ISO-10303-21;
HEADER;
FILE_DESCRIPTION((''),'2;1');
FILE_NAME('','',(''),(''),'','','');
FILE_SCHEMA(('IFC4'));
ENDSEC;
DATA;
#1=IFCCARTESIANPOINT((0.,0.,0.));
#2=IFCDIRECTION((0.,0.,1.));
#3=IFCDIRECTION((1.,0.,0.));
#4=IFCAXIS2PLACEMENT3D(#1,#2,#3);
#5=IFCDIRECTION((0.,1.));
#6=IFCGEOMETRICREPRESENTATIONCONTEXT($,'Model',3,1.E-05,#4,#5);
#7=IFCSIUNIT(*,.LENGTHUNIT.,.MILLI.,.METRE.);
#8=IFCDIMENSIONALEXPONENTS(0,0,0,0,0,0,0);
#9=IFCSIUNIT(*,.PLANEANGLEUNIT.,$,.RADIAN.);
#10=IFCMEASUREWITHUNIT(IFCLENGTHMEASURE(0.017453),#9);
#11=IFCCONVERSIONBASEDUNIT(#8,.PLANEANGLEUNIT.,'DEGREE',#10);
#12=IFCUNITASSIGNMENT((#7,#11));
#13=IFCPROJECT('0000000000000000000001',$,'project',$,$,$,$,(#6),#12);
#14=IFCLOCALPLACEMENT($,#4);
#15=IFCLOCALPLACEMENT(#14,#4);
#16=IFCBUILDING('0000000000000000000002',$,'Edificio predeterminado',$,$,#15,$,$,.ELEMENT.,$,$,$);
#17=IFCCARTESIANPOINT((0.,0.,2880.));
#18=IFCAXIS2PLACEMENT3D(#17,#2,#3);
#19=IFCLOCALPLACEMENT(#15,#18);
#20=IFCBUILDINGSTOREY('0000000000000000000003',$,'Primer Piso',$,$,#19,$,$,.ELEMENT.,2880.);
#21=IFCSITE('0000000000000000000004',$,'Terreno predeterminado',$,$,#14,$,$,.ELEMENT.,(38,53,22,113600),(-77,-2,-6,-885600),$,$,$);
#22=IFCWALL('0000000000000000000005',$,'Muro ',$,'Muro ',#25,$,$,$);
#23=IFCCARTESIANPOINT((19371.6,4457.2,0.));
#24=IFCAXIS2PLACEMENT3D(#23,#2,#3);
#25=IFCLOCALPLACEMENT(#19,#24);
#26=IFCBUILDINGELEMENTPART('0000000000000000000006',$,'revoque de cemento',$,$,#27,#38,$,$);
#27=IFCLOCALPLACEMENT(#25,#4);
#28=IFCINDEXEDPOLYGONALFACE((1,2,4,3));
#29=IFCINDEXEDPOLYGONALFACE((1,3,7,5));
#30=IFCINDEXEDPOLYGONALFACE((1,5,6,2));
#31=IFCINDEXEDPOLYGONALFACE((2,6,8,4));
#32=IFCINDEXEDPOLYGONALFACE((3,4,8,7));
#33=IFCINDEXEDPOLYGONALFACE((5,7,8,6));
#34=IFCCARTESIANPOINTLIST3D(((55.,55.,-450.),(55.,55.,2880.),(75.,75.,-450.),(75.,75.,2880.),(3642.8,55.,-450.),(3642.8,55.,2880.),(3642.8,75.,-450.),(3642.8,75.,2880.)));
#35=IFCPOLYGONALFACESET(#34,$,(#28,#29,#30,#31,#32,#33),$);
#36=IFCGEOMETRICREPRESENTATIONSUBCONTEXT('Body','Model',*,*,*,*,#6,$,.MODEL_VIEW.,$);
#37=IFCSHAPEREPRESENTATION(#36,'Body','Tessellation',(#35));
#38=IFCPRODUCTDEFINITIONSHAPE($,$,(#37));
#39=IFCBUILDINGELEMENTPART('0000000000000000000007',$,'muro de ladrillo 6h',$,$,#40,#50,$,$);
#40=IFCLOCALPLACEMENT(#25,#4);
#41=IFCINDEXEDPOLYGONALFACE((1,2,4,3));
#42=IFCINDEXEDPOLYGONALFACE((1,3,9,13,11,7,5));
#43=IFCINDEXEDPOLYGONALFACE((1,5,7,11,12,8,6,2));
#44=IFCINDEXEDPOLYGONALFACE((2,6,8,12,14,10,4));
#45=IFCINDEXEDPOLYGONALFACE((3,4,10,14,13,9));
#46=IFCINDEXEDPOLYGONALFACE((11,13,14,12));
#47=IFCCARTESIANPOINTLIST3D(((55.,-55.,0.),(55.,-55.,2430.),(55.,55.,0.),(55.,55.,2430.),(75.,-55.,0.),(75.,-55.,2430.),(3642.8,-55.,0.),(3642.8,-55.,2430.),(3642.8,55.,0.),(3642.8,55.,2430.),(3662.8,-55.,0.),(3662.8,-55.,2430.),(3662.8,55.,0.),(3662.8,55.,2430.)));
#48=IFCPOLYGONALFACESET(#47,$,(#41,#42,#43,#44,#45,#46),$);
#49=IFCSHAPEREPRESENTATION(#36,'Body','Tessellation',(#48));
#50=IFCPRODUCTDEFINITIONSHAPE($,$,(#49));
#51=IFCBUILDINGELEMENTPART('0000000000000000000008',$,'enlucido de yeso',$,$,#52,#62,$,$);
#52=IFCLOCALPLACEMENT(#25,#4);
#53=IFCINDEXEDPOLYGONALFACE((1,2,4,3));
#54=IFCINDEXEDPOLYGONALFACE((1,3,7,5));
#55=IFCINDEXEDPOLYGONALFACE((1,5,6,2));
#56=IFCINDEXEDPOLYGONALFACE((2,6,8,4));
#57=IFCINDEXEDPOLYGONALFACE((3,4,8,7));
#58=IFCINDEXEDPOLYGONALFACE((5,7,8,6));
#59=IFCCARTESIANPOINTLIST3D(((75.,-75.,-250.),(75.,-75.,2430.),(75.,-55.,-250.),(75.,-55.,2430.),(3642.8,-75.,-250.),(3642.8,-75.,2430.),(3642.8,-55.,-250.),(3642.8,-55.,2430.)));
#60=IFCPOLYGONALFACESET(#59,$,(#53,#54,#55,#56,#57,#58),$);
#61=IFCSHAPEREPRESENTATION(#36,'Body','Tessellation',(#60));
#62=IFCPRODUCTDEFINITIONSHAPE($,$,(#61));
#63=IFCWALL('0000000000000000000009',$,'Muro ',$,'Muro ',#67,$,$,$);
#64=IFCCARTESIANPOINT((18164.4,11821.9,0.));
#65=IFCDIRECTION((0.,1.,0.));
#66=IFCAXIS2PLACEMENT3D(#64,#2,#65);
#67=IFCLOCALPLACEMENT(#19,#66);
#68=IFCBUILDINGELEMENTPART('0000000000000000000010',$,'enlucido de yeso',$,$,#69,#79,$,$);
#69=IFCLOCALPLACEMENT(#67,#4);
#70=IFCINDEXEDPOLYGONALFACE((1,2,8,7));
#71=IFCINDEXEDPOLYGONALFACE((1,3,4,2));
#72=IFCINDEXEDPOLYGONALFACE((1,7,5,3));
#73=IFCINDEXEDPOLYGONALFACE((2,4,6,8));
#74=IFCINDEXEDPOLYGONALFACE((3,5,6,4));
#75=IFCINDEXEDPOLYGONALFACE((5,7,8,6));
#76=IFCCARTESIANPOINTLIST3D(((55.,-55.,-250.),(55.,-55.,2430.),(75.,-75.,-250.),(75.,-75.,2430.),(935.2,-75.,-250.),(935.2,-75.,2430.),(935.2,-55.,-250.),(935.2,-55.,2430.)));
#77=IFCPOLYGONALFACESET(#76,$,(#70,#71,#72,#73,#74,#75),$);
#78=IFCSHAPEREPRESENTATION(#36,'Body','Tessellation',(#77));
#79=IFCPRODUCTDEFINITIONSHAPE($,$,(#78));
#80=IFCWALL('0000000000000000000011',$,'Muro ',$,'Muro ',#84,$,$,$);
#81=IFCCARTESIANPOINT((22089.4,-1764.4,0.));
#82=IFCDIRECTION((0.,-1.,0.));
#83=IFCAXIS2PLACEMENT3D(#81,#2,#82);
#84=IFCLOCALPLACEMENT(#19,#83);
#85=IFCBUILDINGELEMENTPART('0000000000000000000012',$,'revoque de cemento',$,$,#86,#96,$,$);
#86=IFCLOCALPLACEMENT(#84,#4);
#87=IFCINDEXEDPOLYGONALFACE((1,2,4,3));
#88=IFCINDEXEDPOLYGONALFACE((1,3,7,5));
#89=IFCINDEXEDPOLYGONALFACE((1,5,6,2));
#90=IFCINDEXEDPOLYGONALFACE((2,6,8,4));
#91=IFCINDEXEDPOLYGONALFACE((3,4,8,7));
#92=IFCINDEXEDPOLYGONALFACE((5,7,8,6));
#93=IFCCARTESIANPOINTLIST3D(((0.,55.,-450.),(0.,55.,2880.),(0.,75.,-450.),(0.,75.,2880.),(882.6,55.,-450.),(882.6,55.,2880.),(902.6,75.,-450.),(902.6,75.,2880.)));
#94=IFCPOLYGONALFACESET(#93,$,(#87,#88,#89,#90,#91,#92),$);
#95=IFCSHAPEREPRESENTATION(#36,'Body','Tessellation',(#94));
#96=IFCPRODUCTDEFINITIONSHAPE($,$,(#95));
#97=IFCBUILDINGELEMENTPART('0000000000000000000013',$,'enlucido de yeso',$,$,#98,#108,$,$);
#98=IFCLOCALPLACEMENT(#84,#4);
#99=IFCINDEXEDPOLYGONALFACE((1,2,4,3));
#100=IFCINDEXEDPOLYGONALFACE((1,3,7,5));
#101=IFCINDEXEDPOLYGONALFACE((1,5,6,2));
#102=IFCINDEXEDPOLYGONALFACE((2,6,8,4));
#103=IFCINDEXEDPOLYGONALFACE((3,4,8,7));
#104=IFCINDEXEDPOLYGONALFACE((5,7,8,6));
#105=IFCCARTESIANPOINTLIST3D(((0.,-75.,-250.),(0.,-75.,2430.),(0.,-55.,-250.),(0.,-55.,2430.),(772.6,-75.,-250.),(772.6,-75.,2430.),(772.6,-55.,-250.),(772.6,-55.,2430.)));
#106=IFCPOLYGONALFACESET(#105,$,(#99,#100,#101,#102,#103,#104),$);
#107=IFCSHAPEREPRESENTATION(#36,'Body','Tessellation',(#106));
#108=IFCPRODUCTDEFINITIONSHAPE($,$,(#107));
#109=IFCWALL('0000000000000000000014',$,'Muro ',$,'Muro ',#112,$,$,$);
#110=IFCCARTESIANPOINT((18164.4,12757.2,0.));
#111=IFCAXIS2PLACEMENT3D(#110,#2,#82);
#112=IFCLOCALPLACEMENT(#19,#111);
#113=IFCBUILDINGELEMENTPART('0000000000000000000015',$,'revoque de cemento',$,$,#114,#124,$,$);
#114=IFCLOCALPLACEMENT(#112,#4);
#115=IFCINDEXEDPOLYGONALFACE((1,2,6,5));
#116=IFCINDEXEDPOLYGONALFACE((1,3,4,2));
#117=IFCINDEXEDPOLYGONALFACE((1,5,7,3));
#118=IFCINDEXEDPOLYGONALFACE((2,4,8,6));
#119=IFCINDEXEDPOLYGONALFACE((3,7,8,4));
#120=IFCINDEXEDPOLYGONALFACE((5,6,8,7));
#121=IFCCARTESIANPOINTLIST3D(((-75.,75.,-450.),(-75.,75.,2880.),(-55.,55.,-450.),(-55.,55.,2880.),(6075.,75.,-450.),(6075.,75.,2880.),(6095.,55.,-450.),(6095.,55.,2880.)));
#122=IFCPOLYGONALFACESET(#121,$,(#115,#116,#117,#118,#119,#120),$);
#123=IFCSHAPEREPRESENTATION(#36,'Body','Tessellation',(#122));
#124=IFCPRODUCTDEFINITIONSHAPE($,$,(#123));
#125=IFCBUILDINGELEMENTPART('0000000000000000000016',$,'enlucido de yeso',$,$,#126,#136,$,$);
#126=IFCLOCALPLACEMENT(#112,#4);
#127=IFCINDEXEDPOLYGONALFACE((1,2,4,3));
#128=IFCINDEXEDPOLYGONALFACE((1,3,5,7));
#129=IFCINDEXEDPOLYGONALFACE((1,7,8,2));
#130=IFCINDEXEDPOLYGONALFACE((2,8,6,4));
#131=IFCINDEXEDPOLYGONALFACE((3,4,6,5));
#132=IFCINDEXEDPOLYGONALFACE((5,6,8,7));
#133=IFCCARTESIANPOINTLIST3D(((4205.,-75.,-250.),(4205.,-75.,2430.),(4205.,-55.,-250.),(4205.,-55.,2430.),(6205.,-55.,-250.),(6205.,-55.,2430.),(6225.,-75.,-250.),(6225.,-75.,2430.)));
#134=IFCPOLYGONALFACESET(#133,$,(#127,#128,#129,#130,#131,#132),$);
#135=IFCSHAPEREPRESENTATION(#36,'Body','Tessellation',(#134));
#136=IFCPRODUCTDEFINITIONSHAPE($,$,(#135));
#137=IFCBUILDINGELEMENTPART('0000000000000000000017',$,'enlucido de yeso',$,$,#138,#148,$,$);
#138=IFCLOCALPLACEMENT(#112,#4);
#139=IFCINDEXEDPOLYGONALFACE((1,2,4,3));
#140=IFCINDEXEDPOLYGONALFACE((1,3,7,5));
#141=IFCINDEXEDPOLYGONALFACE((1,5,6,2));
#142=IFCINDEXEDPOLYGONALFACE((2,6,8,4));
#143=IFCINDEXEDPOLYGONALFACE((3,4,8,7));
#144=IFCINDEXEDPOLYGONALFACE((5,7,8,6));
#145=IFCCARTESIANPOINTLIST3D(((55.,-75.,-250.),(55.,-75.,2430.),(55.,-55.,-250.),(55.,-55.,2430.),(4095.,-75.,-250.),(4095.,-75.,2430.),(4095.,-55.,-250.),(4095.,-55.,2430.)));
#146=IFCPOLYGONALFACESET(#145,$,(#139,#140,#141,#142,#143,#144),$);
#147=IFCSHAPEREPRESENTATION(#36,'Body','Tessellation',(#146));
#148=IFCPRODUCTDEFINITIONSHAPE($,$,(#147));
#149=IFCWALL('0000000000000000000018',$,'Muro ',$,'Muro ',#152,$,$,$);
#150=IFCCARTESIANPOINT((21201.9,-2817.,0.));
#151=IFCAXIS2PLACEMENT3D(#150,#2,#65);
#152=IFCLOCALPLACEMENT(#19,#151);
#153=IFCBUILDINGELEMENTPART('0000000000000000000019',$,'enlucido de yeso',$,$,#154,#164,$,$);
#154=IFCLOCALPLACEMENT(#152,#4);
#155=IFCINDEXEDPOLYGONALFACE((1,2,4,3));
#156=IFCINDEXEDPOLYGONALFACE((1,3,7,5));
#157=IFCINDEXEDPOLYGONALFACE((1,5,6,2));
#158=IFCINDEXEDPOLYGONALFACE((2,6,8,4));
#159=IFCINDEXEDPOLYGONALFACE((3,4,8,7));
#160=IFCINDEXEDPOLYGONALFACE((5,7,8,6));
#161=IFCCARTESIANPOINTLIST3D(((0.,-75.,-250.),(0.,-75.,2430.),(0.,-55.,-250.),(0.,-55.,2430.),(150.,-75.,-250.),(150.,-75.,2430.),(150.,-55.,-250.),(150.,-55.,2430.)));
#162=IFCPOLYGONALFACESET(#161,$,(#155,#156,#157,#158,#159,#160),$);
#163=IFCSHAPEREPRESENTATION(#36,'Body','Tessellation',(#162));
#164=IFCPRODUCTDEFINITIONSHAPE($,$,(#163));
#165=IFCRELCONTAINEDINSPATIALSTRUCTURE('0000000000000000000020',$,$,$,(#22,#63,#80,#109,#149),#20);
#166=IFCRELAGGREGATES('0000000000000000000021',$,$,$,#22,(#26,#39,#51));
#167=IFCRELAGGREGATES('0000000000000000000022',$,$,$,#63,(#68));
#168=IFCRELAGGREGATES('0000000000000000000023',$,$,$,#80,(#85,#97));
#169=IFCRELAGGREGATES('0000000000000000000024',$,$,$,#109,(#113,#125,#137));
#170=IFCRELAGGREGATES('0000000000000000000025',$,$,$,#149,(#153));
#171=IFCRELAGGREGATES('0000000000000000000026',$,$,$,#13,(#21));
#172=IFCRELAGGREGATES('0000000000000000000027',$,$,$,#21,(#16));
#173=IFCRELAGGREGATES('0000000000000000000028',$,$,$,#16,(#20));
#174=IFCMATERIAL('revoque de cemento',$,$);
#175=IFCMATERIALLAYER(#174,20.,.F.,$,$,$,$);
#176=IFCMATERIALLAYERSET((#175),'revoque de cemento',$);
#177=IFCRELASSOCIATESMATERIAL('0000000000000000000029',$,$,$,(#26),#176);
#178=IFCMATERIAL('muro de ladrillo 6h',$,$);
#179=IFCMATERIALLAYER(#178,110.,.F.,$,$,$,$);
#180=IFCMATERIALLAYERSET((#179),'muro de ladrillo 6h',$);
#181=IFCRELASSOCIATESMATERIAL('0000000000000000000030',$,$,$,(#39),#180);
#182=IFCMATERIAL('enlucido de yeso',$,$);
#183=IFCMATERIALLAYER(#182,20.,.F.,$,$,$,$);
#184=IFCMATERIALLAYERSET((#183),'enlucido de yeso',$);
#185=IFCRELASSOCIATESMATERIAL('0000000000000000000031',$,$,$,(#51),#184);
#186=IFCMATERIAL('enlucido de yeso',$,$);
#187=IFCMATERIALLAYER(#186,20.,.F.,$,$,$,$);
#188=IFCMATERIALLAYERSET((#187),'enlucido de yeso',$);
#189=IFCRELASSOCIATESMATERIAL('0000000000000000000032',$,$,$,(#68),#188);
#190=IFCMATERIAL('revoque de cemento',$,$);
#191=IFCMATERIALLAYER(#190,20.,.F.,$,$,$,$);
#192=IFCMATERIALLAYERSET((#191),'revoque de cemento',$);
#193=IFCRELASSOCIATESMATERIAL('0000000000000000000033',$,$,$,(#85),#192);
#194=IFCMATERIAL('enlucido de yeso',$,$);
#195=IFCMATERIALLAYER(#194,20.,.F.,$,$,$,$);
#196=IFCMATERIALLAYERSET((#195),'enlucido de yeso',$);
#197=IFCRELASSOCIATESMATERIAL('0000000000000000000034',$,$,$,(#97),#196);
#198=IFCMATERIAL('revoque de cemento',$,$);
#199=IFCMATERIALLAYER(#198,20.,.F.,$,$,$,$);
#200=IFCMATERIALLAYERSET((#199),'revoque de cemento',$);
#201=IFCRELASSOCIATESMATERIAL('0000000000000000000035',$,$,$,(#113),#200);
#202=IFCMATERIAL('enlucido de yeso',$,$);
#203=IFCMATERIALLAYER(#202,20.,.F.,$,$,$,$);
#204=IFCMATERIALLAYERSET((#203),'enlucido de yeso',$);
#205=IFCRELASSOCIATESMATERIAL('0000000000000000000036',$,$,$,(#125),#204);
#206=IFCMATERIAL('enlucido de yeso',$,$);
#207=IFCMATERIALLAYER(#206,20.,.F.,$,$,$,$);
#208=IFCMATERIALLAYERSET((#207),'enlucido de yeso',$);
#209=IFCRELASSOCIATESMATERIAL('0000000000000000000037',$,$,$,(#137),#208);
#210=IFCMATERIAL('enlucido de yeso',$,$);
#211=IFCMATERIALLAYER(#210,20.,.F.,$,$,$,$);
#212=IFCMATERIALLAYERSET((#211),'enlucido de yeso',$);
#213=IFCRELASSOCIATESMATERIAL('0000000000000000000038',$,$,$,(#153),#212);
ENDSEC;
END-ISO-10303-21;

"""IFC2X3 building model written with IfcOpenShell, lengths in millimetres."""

from ifc_helpers import new_model, entity, si_unit, converted_unit, direction, frame, origin_with_axes, place, context, subcontext, project, spatial, polyline, outline, extrude, clip, bounded_halfspace, material, layer, layer_set, layer_usage, element, aggregate, save


model = new_model("IFC2X3")

# Units and contexts
model_context = context("Model", 3, precision=1e-05, world=origin_with_axes(), true_north=direction((0.0, 1.0)))
body_context = subcontext(model_context, "Body", "Model", "MODEL_VIEW")
ifc_project = project(units=[si_unit("LENGTHUNIT", "METRE", prefix="MILLI"), converted_unit("PLANEANGLEUNIT", "DEGREE", entity("IfcLengthMeasure", 0.017453), si_unit("PLANEANGLEUNIT", "RADIAN"), dimensions=[0, 0, 0, 0, 0, 0, 0])], contexts=[model_context])

# Site, building, storey
site_placement = place(None, origin_with_axes())
site = spatial("IfcSite", under=ifc_project, at=site_placement, Name="Terreno predeterminado", CompositionType="ELEMENT", RefLatitude=(38, 53, 22, 113600), RefLongitude=(-77, -2, -6, -885600))
building_placement = place(site_placement, origin_with_axes())
building = spatial("IfcBuilding", under=site, at=building_placement, Name="Edificio predeterminado", CompositionType="ELEMENT")
storey_placement = place(building_placement, frame((0.0, 0.0, 2880.0), z_axis=(0.0, 0.0, 1.0), x_axis=(1.0, 0.0, 0.0)))
storey = spatial("IfcBuildingStorey", under=building, at=storey_placement, Name="Primer Piso", CompositionType="ELEMENT", Elevation=2880.0)

# Walls, building element parts
wall_1_placement = place(storey_placement, frame((19371.6, 4457.2, 0.0), z_axis=(0.0, 0.0, 1.0), x_axis=(1.0, 0.0, 0.0)))
wall_1 = element("IfcWall", 1, at=wall_1_placement, inside=storey, Name="Muro ", ObjectType="Muro ")
ifc_material_1 = material(Name="revoque de cemento")
ifc_layer_1 = layer(ifc_material_1, 20.0, ventilated=False)
ifc_layer_set_1 = layer_set([ifc_layer_1], Name="revoque de cemento")
ifc_layer_usage_1 = layer_usage(ifc_layer_set_1, "AXIS2", "NEGATIVE", -75.0)
building_element_part_1_placement = place(wall_1_placement, origin_with_axes())
building_element_part_1 = element("IfcBuildingElementPart", 2, at=building_element_part_1_placement, material=ifc_layer_usage_1, Name="revoque de cemento", context=body_context, shape_type="SweptSolid", body=[
    extrude(outline(polyline([(3642.8, 75.0), (3642.8, 55.0), (55.0, 55.0), (75.0, 75.0), (3642.8, 75.0)])), frame((0.0, 0.0, -450.0), z_axis=(0.0, 0.0, 1.0), x_axis=(1.0, 0.0, 0.0)), (0.0, 0.0, 1.0), 3330.0),
])
ifc_material_2 = material(Name="muro de ladrillo 6h")
ifc_layer_2 = layer(ifc_material_2, 110.0, ventilated=False)
ifc_layer_set_2 = layer_set([ifc_layer_2], Name="muro de ladrillo 6h")
ifc_layer_usage_2 = layer_usage(ifc_layer_set_2, "AXIS2", "NEGATIVE", -55.0)
building_element_part_2_placement = place(wall_1_placement, origin_with_axes())
building_element_part_2 = element("IfcBuildingElementPart", 3, at=building_element_part_2_placement, material=ifc_layer_usage_2, Name="muro de ladrillo 6h", context=body_context, shape_type="SweptSolid", body=[
    extrude(outline(polyline([(3662.8, 55.0), (3662.8, -55.0), (3642.8, -55.0), (75.0, -55.0), (55.0, -55.0), (55.0, 55.0), (3642.8, 55.0), (3662.8, 55.0)])), origin_with_axes(), (0.0, 0.0, 1.0), 2430.0),
])
ifc_material_3 = material(Name="enlucido de yeso")
ifc_layer_3 = layer(ifc_material_3, 20.0, ventilated=False)
ifc_layer_set_3 = layer_set([ifc_layer_3], Name="enlucido de yeso")
ifc_layer_usage_3 = layer_usage(ifc_layer_set_3, "AXIS2", "NEGATIVE", 55.0)
building_element_part_3_placement = place(wall_1_placement, origin_with_axes())
building_element_part_3 = element("IfcBuildingElementPart", 4, at=building_element_part_3_placement, material=ifc_layer_usage_3, Name="enlucido de yeso", context=body_context, shape_type="SweptSolid", body=[
    extrude(outline(polyline([(3642.8, -55.0), (3642.8, -75.0), (75.0, -75.0), (75.0, -55.0), (3642.8, -55.0)])), frame((0.0, 0.0, -250.0), z_axis=(0.0, 0.0, 1.0), x_axis=(1.0, 0.0, 0.0)), (0.0, 0.0, 1.0), 2680.0),
])
aggregate(wall_1, [building_element_part_1, building_element_part_2, building_element_part_3])
wall_2_placement = place(storey_placement, frame((18164.4, 11821.9, 0.0), z_axis=(0.0, 0.0, 1.0), x_axis=(0.0, 1.0, 0.0)))
wall_2 = element("IfcWall", 5, at=wall_2_placement, inside=storey, Name="Muro ", ObjectType="Muro ")
ifc_material_4 = material(Name="enlucido de yeso")
ifc_layer_4 = layer(ifc_material_4, 20.0, ventilated=False)
ifc_layer_set_4 = layer_set([ifc_layer_4], Name="enlucido de yeso")
ifc_layer_usage_4 = layer_usage(ifc_layer_set_4, "AXIS2", "NEGATIVE", 55.0)
building_element_part_4_placement = place(wall_2_placement, origin_with_axes())
building_element_part_4 = element("IfcBuildingElementPart", 6, at=building_element_part_4_placement, material=ifc_layer_usage_4, Name="enlucido de yeso", context=body_context, shape_type="SweptSolid", body=[
    extrude(outline(polyline([(935.2, -55.0), (935.2, -75.0), (75.0, -75.0), (55.0, -55.0), (935.2, -55.0)])), frame((0.0, 0.0, -250.0), z_axis=(0.0, 0.0, 1.0), x_axis=(1.0, 0.0, 0.0)), (0.0, 0.0, 1.0), 2680.0),
])
aggregate(wall_2, [building_element_part_4])
wall_3_placement = place(storey_placement, frame((22089.4, -1764.4, 0.0), z_axis=(0.0, 0.0, 1.0), x_axis=(0.0, -1.0, 0.0)))
wall_3 = element("IfcWall", 7, at=wall_3_placement, inside=storey, Name="Muro ", ObjectType="Muro ")
ifc_material_5 = material(Name="revoque de cemento")
ifc_layer_5 = layer(ifc_material_5, 20.0, ventilated=False)
ifc_layer_set_5 = layer_set([ifc_layer_5], Name="revoque de cemento")
ifc_layer_usage_5 = layer_usage(ifc_layer_set_5, "AXIS2", "NEGATIVE", -75.0)
building_element_part_5_placement = place(wall_3_placement, origin_with_axes())
building_element_part_5 = element("IfcBuildingElementPart", 8, at=building_element_part_5_placement, material=ifc_layer_usage_5, Name="revoque de cemento", context=body_context, shape_type="SweptSolid", body=[
    extrude(outline(polyline([(902.6, 75.0), (882.6, 55.0), (0.0, 55.0), (0.0, 75.0), (902.6, 75.0)])), frame((0.0, 0.0, -450.0), z_axis=(0.0, 0.0, 1.0), x_axis=(1.0, 0.0, 0.0)), (0.0, 0.0, 1.0), 3330.0),
])
ifc_material_6 = material(Name="enlucido de yeso")
ifc_layer_6 = layer(ifc_material_6, 20.0, ventilated=False)
ifc_layer_set_6 = layer_set([ifc_layer_6], Name="enlucido de yeso")
ifc_layer_usage_6 = layer_usage(ifc_layer_set_6, "AXIS2", "NEGATIVE", 55.0)
building_element_part_6_placement = place(wall_3_placement, origin_with_axes())
building_element_part_6 = element("IfcBuildingElementPart", 9, at=building_element_part_6_placement, material=ifc_layer_usage_6, Name="enlucido de yeso", context=body_context, shape_type="SweptSolid", body=[
    extrude(outline(polyline([(772.6, -55.0), (772.6, -75.0), (0.0, -75.0), (0.0, -55.0), (772.6, -55.0)])), frame((0.0, 0.0, -250.0), z_axis=(0.0, 0.0, 1.0), x_axis=(1.0, 0.0, 0.0)), (0.0, 0.0, 1.0), 2680.0),
])
aggregate(wall_3, [building_element_part_5, building_element_part_6])
wall_4_placement = place(storey_placement, frame((18164.4, 12757.2, 0.0), z_axis=(0.0, 0.0, 1.0), x_axis=(0.0, -1.0, 0.0)))
wall_4 = element("IfcWall", 10, at=wall_4_placement, inside=storey, Name="Muro ", ObjectType="Muro ")
ifc_material_7 = material(Name="revoque de cemento")
ifc_layer_7 = layer(ifc_material_7, 20.0, ventilated=False)
ifc_layer_set_7 = layer_set([ifc_layer_7], Name="revoque de cemento")
ifc_layer_usage_7 = layer_usage(ifc_layer_set_7, "AXIS2", "NEGATIVE", -75.0)
building_element_part_7_placement = place(wall_4_placement, origin_with_axes())
building_element_part_7 = element("IfcBuildingElementPart", 11, at=building_element_part_7_placement, material=ifc_layer_usage_7, Name="revoque de cemento", context=body_context, shape_type="SweptSolid", body=[
    extrude(outline(polyline([(6075.0, 75.0), (6095.0, 55.0), (-55.0, 55.0), (-75.0, 75.0), (6075.0, 75.0)])), frame((0.0, 0.0, -450.0), z_axis=(0.0, 0.0, 1.0), x_axis=(1.0, 0.0, 0.0)), (0.0, 0.0, 1.0), 3330.0),
])
ifc_material_8 = material(Name="enlucido de yeso")
ifc_layer_8 = layer(ifc_material_8, 20.0, ventilated=False)
ifc_layer_set_8 = layer_set([ifc_layer_8], Name="enlucido de yeso")
ifc_layer_usage_8 = layer_usage(ifc_layer_set_8, "AXIS2", "NEGATIVE", 55.0)
building_element_part_8_placement = place(wall_4_placement, origin_with_axes())
building_element_part_8 = element("IfcBuildingElementPart", 12, at=building_element_part_8_placement, material=ifc_layer_usage_8, Name="enlucido de yeso", context=body_context, shape_type="SweptSolid", body=[
    extrude(outline(polyline([(6205.0, -55.0), (6225.0, -75.0), (4205.0, -75.0), (4205.0, -55.0), (6205.0, -55.0)])), frame((0.0, 0.0, -250.0), z_axis=(0.0, 0.0, 1.0), x_axis=(1.0, 0.0, 0.0)), (0.0, 0.0, 1.0), 2680.0),
])
ifc_material_9 = material(Name="enlucido de yeso")
ifc_layer_9 = layer(ifc_material_9, 20.0, ventilated=False)
ifc_layer_set_9 = layer_set([ifc_layer_9], Name="enlucido de yeso")
ifc_layer_usage_9 = layer_usage(ifc_layer_set_9, "AXIS2", "NEGATIVE", 55.0)
building_element_part_9_placement = place(wall_4_placement, origin_with_axes())
building_element_part_9 = element("IfcBuildingElementPart", 13, at=building_element_part_9_placement, material=ifc_layer_usage_9, Name="enlucido de yeso", context=body_context, shape_type="SweptSolid", body=[
    extrude(outline(polyline([(4095.0, -55.0), (4095.0, -75.0), (55.0, -75.0), (55.0, -55.0), (4095.0, -55.0)])), frame((0.0, 0.0, -250.0), z_axis=(0.0, 0.0, 1.0), x_axis=(1.0, 0.0, 0.0)), (0.0, 0.0, 1.0), 2680.0),
])
aggregate(wall_4, [building_element_part_7, building_element_part_8, building_element_part_9])
wall_5_placement = place(storey_placement, frame((21201.9, -2817.0, 0.0), z_axis=(0.0, 0.0, 1.0), x_axis=(0.0, 1.0, 0.0)))
wall_5 = element("IfcWall", 14, at=wall_5_placement, inside=storey, Name="Muro ", ObjectType="Muro ")
ifc_material_10 = material(Name="enlucido de yeso")
ifc_layer_10 = layer(ifc_material_10, 20.0, ventilated=False)
ifc_layer_set_10 = layer_set([ifc_layer_10], Name="enlucido de yeso")
ifc_layer_usage_10 = layer_usage(ifc_layer_set_10, "AXIS2", "NEGATIVE", 55.0)
building_element_part_10_placement = place(wall_5_placement, origin_with_axes())
building_element_part_10 = element("IfcBuildingElementPart", 15, at=building_element_part_10_placement, material=ifc_layer_usage_10, Name="enlucido de yeso", context=body_context, shape_type="Clipping", body=[
    clip(clip(extrude(outline(polyline([(150.0, -55.0), (150.0, -75.0), (0.0, -75.0), (0.0, -55.0), (150.0, -55.0)])), frame((0.0, 0.0, -250.0), z_axis=(0.0, 0.0, 1.0), x_axis=(1.0, 0.0, 0.0)), (0.0, 0.0, 1.0), 2680.0), bounded_halfspace(frame((0.0, 0.0, -250.0), z_axis=(0.0, 0.0, 1.0), x_axis=(1.0, 0.0, 0.0)), True, origin_with_axes(), polyline([(-150.0, -150.0), (375.0, -150.0), (375.0, 150.0), (-150.0, 150.0), (-150.0, -150.0)]))), bounded_halfspace(frame((0.0, 0.0, 2430.0), z_axis=(0.0, 0.0, 1.0), x_axis=(1.0, 0.0, 0.0)), False, origin_with_axes(), polyline([(-150.0, -150.0), (375.0, -150.0), (375.0, 150.0), (-150.0, 150.0), (-150.0, -150.0)]))),
])
aggregate(wall_5, [building_element_part_10])

save(model, "model.ifc")
